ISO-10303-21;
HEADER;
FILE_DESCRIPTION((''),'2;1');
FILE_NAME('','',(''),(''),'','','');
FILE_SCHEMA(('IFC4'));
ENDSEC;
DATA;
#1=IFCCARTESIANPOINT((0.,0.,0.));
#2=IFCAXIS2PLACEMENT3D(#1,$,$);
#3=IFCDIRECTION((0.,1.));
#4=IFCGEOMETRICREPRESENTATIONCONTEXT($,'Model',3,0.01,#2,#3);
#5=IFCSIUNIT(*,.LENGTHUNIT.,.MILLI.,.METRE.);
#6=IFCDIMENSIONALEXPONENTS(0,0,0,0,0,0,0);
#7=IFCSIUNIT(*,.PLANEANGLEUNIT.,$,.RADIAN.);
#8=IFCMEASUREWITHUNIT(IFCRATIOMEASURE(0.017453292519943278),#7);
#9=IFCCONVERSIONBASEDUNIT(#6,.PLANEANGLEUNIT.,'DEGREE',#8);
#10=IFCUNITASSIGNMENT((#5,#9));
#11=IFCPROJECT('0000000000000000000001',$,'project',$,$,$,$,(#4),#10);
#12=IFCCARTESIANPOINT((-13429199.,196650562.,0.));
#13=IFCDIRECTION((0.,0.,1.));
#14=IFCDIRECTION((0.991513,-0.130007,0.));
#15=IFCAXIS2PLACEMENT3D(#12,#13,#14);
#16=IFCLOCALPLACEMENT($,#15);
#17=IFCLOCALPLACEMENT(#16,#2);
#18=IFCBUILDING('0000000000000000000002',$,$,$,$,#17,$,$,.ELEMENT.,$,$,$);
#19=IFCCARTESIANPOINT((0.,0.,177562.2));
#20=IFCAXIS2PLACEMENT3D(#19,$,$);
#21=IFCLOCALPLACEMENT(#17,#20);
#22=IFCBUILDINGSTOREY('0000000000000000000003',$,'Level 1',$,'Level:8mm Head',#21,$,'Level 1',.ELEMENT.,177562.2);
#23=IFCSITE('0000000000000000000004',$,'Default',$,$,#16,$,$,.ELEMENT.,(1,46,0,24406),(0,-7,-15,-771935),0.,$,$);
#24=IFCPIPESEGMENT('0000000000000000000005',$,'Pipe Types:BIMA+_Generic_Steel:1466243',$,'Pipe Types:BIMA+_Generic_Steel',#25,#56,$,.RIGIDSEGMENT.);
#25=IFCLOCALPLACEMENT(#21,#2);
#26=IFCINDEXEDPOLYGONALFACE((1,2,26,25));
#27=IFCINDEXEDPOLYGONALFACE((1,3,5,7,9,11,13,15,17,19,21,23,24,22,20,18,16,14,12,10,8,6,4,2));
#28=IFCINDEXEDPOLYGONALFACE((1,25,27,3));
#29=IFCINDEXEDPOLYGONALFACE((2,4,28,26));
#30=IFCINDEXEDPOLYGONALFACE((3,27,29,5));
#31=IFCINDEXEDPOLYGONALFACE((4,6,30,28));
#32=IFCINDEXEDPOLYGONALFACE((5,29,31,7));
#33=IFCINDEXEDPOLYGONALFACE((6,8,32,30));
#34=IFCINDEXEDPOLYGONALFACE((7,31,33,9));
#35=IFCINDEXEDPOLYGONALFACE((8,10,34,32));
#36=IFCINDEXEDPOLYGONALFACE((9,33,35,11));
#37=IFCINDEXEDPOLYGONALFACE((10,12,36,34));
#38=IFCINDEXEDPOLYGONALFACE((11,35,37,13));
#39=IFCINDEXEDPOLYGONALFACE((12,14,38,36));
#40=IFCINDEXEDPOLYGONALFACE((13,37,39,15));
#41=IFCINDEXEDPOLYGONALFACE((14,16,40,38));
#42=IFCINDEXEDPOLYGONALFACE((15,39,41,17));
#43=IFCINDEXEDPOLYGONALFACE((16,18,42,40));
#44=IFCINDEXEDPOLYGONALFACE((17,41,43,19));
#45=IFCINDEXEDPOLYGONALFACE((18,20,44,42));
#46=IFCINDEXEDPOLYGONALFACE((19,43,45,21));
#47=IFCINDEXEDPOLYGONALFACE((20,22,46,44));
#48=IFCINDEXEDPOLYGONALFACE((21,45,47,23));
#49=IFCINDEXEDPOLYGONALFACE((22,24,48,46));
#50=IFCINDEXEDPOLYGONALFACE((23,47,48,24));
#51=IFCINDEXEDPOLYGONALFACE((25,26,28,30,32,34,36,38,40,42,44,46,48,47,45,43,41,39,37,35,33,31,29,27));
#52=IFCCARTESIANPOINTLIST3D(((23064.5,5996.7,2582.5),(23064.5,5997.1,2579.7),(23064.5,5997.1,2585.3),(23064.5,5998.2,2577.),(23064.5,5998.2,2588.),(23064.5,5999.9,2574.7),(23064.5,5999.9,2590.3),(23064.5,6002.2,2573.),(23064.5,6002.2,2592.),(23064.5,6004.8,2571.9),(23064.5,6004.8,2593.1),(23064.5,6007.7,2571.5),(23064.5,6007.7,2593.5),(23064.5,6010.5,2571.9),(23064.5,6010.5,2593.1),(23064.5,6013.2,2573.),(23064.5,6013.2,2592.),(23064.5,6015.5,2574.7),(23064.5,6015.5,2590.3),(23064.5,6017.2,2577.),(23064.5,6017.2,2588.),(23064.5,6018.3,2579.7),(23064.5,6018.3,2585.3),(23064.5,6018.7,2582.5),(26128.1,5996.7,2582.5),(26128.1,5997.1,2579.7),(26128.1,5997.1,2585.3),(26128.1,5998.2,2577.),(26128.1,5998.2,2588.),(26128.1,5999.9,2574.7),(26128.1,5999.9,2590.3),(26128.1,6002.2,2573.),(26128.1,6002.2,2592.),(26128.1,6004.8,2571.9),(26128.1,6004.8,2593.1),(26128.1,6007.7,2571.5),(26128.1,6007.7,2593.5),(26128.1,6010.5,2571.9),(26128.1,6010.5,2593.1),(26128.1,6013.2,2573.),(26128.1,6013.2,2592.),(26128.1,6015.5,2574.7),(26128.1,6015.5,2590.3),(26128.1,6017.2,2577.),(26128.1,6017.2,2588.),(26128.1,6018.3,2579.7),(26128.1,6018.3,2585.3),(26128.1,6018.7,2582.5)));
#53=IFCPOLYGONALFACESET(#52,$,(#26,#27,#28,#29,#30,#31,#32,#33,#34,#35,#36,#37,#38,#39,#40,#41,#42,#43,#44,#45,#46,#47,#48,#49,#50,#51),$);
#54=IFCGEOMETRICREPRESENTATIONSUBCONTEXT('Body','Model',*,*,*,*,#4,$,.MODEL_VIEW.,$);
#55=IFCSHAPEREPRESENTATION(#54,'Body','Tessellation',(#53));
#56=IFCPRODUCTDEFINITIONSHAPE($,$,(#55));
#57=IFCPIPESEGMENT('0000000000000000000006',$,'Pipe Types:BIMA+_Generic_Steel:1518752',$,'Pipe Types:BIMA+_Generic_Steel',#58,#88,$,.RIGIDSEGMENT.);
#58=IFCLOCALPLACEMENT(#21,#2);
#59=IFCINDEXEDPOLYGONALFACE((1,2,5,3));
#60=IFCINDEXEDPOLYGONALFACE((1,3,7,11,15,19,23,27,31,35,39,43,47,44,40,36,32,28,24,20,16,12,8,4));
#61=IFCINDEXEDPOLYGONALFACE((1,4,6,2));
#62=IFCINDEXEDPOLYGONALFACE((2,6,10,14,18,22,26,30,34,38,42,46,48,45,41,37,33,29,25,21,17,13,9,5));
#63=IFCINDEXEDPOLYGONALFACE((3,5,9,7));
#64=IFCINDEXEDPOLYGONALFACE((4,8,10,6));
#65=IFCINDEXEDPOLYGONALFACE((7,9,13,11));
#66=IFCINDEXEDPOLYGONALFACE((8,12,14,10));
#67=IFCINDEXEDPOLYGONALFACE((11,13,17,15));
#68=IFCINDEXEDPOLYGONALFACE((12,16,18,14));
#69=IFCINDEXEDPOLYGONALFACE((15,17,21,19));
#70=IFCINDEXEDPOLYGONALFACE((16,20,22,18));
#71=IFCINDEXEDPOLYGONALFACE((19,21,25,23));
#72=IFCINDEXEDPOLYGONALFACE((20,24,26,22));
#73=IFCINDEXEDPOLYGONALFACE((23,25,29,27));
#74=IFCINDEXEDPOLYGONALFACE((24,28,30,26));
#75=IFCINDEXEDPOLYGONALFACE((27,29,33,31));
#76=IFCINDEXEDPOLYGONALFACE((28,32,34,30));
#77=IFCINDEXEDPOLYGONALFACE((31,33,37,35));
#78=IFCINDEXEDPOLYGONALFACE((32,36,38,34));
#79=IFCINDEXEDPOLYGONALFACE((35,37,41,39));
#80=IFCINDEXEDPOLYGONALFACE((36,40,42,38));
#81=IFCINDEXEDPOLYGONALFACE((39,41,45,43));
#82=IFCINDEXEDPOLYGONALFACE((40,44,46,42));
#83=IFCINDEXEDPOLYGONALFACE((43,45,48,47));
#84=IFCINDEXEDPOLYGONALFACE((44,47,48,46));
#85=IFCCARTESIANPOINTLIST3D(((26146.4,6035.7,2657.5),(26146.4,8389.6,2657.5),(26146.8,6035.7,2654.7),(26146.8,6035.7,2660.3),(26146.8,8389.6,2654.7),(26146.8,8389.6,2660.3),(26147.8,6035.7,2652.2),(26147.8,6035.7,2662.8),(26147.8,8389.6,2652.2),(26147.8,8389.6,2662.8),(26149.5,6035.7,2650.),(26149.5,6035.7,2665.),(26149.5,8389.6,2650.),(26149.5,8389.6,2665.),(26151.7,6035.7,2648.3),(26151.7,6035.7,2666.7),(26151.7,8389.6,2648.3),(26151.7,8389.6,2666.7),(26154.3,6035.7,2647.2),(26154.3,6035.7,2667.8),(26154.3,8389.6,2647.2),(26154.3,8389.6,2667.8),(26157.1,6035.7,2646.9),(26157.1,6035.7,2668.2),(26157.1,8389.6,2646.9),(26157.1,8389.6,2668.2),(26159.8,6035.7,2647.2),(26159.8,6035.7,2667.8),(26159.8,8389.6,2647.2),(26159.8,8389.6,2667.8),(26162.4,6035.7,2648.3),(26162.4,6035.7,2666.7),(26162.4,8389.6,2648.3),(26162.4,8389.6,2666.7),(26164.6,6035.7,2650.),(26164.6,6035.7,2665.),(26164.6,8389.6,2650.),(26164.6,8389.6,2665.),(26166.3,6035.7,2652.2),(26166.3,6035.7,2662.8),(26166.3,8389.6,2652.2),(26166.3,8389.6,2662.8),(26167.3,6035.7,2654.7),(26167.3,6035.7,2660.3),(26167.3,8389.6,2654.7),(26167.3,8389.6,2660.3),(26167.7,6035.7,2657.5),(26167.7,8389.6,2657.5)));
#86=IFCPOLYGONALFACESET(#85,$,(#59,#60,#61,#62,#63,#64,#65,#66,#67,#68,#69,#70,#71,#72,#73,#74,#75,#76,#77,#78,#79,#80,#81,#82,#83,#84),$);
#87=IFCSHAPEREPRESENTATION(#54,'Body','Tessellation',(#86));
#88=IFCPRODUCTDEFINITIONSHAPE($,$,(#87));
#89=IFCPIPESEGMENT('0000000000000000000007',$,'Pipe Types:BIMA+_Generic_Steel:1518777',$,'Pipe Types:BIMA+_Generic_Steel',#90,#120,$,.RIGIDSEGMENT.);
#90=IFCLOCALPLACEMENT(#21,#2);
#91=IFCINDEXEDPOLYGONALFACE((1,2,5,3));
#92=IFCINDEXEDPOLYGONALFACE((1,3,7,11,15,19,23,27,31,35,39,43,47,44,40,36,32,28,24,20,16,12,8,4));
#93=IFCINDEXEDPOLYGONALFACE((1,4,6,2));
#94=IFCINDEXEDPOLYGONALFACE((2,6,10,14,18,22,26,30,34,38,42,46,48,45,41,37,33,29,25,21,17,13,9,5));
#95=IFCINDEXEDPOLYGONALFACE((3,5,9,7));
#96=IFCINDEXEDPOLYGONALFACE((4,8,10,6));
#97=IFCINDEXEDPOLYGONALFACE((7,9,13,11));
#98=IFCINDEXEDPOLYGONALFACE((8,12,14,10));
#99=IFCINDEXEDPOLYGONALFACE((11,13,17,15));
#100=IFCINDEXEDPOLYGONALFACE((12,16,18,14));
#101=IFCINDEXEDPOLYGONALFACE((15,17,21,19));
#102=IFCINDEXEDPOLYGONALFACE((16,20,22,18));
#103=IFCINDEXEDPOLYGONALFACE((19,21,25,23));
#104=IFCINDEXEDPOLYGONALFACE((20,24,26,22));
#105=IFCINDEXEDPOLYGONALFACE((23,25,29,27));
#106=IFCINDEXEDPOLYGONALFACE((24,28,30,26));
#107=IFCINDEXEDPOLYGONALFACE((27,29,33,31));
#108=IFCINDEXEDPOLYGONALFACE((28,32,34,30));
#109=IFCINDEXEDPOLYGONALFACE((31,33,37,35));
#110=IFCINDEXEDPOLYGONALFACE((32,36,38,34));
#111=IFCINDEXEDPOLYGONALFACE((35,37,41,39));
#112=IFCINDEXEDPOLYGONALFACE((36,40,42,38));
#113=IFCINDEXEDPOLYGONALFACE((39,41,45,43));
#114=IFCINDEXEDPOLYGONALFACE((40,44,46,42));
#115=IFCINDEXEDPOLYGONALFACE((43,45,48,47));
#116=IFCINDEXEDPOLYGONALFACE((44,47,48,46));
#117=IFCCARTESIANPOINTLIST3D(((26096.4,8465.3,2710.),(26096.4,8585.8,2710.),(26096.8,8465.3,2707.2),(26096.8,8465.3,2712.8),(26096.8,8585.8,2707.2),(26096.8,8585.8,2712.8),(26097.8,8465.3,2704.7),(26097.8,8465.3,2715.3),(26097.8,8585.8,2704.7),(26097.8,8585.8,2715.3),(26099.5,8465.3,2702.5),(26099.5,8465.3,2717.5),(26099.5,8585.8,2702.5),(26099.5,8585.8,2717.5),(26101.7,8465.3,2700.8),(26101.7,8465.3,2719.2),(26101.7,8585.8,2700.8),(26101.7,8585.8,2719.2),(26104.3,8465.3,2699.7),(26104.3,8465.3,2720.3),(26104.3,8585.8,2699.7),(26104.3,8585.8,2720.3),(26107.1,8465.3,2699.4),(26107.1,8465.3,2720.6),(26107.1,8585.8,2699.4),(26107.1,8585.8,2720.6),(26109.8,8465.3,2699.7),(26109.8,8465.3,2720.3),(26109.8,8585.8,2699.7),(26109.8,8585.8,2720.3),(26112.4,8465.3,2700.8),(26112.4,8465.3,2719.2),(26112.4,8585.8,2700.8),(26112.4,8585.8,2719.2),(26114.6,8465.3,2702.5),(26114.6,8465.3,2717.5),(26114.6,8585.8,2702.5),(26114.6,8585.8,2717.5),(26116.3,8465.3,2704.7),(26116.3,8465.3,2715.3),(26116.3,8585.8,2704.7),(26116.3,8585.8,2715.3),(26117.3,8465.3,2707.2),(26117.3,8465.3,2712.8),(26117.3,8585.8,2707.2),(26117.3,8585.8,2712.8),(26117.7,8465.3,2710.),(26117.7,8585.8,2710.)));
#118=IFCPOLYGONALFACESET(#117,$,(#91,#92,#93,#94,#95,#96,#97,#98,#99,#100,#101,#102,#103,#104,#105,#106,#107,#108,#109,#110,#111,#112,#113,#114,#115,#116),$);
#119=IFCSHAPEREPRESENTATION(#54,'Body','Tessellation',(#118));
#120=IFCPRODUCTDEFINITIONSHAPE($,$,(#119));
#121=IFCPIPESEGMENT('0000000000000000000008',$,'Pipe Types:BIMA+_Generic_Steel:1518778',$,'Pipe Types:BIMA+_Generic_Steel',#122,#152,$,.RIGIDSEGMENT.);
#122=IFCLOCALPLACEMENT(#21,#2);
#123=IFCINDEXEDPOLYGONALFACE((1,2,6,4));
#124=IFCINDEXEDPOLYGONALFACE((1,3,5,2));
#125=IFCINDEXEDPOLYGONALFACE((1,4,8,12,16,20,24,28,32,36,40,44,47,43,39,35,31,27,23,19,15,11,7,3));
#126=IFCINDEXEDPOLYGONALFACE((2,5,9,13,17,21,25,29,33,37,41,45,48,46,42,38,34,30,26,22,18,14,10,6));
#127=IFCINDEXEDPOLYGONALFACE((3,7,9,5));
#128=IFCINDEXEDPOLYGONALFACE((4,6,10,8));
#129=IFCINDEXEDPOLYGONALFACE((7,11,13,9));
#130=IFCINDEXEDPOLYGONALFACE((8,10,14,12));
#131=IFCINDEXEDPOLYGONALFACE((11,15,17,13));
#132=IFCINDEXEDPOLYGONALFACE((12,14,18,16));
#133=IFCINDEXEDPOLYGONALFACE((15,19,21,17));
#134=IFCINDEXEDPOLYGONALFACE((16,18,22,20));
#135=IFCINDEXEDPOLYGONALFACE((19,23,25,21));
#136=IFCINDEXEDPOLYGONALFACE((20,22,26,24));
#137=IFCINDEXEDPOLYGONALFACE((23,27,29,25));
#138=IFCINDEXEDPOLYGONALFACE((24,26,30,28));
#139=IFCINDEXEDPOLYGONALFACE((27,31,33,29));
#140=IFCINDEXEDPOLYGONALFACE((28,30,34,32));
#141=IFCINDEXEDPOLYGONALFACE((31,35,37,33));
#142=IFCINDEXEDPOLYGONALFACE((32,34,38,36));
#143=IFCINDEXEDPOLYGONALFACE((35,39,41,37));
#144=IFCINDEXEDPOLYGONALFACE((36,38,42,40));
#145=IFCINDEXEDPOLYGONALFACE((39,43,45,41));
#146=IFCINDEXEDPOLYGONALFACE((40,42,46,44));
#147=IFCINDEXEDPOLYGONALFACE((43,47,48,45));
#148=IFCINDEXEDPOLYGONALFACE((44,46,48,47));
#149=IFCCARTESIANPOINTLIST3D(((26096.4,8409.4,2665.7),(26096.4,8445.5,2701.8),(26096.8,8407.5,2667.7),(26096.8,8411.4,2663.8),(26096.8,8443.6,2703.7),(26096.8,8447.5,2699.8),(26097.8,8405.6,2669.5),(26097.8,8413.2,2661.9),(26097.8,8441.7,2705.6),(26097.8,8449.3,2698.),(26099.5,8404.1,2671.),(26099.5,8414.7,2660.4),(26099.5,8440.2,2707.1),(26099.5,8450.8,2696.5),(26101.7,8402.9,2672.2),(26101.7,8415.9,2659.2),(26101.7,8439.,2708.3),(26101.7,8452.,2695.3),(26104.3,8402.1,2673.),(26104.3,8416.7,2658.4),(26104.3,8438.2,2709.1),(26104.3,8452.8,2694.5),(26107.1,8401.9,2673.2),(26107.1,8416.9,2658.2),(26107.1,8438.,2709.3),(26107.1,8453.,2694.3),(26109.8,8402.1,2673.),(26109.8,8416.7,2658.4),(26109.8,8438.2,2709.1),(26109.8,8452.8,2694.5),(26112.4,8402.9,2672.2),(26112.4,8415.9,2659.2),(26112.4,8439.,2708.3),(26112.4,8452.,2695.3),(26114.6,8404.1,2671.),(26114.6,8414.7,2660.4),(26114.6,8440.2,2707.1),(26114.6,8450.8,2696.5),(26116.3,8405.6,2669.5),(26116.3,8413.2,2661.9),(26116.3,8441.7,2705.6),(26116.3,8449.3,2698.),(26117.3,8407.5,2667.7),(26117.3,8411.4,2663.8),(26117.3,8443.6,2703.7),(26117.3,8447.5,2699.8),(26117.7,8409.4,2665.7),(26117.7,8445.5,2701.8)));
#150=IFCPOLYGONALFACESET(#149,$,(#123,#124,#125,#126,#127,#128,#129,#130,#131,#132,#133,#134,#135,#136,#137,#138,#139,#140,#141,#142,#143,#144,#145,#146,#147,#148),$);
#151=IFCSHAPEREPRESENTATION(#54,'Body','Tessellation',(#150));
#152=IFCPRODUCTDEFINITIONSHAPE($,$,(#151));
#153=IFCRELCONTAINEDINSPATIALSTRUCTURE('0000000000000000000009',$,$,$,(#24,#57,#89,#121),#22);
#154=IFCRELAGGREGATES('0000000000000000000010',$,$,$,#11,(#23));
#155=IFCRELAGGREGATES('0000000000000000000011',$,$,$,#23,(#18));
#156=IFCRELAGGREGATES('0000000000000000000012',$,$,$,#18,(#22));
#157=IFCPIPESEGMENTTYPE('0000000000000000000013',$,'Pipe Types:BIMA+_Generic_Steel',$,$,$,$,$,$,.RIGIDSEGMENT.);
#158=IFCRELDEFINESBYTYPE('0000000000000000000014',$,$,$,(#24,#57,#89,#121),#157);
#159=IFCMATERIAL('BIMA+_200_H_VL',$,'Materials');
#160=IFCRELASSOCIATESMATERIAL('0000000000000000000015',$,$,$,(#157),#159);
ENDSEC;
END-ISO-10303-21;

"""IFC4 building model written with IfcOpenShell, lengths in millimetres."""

from ifc_helpers import new_model, entity, si_unit, converted_unit, direction, frame, origin, place, context, subcontext, project, spatial, arc, indexed_curve, outline, extrude, material, type_object, element, save


model = new_model("IFC4")

# Units and contexts
model_context = context("Model", 3, precision=0.01, world=origin(), true_north=direction((0.0, 1.0)))
body_context = subcontext(model_context, "Body", "Model", "MODEL_VIEW")
ifc_project = project(units=[si_unit("LENGTHUNIT", "METRE", prefix="MILLI"), converted_unit("PLANEANGLEUNIT", "DEGREE", entity("IfcRatioMeasure", 0.017453292519943278), si_unit("PLANEANGLEUNIT", "RADIAN"), dimensions=[0, 0, 0, 0, 0, 0, 0])], contexts=[model_context])

# Site, building, storey
site_placement = place(None, frame((-13429199.0, 196650562.0, 0.0), z_axis=(0.0, 0.0, 1.0), x_axis=(0.991513, -0.130007, 0.0)))
site = spatial("IfcSite", under=ifc_project, at=site_placement, Name="Default", CompositionType="ELEMENT", RefLatitude=(1, 46, 0, 24406), RefLongitude=(0, -7, -15, -771935), RefElevation=0.0)
building_placement = place(site_placement, origin())
building = spatial("IfcBuilding", under=site, at=building_placement, CompositionType="ELEMENT")
storey_placement = place(building_placement, frame((0.0, 0.0, 177562.2)))
storey = spatial("IfcBuildingStorey", under=building, at=storey_placement, Name="Level 1", ObjectType="Level:8mm Head", LongName="Level 1", CompositionType="ELEMENT", Elevation=177562.2)

# Pipe segments
ifc_material_1 = material(Name="BIMA+_200_H_VL", Category="Materials")
pipe_segment_type_1 = type_object("IfcPipeSegmentType", Name="Pipe Types:BIMA+_Generic_Steel", PredefinedType="RIGIDSEGMENT", material=ifc_material_1)
pipe_segment_1_placement = place(storey_placement, frame((23064.5, 5995.1, 2569.9)))
element("IfcPipeSegment", 1, at=pipe_segment_1_placement, inside=storey, type_object=pipe_segment_type_1, Name="Pipe Types:BIMA+_Generic_Steel:1466243", ObjectType="Pipe Types:BIMA+_Generic_Steel", PredefinedType="RIGIDSEGMENT", context=body_context, shape_type="SweptSolid", body=[
    extrude(outline(indexed_curve([(11.0, 0.0), (7.8, 7.8), (0.0, 11.0), (-7.8, 7.8), (-11.0, 0.0), (-7.8, -7.8), (0.0, -11.0), (7.8, -7.8)], segments=[arc(1, 2, 3), arc(3, 4, 5), arc(5, 6, 7), arc(7, 8, 1)], self_intersect=False)), frame((0.0, 12.6, 12.6), z_axis=(1.0, 0.0, 0.0), x_axis=(0.0, -1.0, 0.0)), (0.0, 0.0, 1.0), 3063.5),
])
pipe_segment_2_placement = place(storey_placement, frame((26144.8, 6035.7, 2645.3)))
element("IfcPipeSegment", 2, at=pipe_segment_2_placement, inside=storey, type_object=pipe_segment_type_1, Name="Pipe Types:BIMA+_Generic_Steel:1518752", ObjectType="Pipe Types:BIMA+_Generic_Steel", PredefinedType="RIGIDSEGMENT", context=body_context, shape_type="SweptSolid", body=[
    extrude(outline(indexed_curve([(10.7, 0.0), (7.5, 7.5), (0.0, 10.7), (-7.5, 7.5), (-10.7, 0.0), (-7.5, -7.5), (0.0, -10.7), (7.5, -7.5)], segments=[arc(1, 2, 3), arc(3, 4, 5), arc(5, 6, 7), arc(7, 8, 1)], self_intersect=False)), frame((12.2, 0.0, 12.2), z_axis=(0.0, 1.0, 0.0), x_axis=(1.0, 0.0, 0.0)), (0.0, 0.0, 1.0), 2353.9),
])
pipe_segment_3_placement = place(storey_placement, frame((26094.8, 8465.3, 2697.8)))
element("IfcPipeSegment", 3, at=pipe_segment_3_placement, inside=storey, type_object=pipe_segment_type_1, Name="Pipe Types:BIMA+_Generic_Steel:1518777", ObjectType="Pipe Types:BIMA+_Generic_Steel", PredefinedType="RIGIDSEGMENT", context=body_context, shape_type="SweptSolid", body=[
    extrude(outline(indexed_curve([(10.7, 0.0), (7.5, 7.5), (0.0, 10.7), (-7.5, 7.5), (-10.7, 0.0), (-7.5, -7.5), (0.0, -10.7), (7.5, -7.5)], segments=[arc(1, 2, 3), arc(3, 4, 5), arc(5, 6, 7), arc(7, 8, 1)], self_intersect=False)), frame((12.2, 0.0, 12.2), z_axis=(0.0, 1.0, 0.0), x_axis=(-1.0, 0.0, 0.0)), (0.0, 0.0, 1.0), 120.5),
])
pipe_segment_4_placement = place(storey_placement, frame((26094.8, 8400.3, 2656.6)))
element("IfcPipeSegment", 4, at=pipe_segment_4_placement, inside=storey, type_object=pipe_segment_type_1, Name="Pipe Types:BIMA+_Generic_Steel:1518778", ObjectType="Pipe Types:BIMA+_Generic_Steel", PredefinedType="RIGIDSEGMENT", context=body_context, shape_type="SweptSolid", body=[
    extrude(outline(indexed_curve([(10.7, 0.0), (7.5, 7.5), (0.0, 10.7), (-7.5, 7.5), (-10.7, 0.0), (-7.5, -7.5), (0.0, -10.7), (7.5, -7.5)], segments=[arc(1, 2, 3), arc(3, 4, 5), arc(5, 6, 7), arc(7, 8, 1)], self_intersect=False)), frame((12.2, 9.1, 9.1), z_axis=(0.0, 0.707107, 0.707107), x_axis=(-1.0, 0.0, 0.0)), (0.0, 0.0, 1.0), 51.1),
])

save(model, "model.ifc")
